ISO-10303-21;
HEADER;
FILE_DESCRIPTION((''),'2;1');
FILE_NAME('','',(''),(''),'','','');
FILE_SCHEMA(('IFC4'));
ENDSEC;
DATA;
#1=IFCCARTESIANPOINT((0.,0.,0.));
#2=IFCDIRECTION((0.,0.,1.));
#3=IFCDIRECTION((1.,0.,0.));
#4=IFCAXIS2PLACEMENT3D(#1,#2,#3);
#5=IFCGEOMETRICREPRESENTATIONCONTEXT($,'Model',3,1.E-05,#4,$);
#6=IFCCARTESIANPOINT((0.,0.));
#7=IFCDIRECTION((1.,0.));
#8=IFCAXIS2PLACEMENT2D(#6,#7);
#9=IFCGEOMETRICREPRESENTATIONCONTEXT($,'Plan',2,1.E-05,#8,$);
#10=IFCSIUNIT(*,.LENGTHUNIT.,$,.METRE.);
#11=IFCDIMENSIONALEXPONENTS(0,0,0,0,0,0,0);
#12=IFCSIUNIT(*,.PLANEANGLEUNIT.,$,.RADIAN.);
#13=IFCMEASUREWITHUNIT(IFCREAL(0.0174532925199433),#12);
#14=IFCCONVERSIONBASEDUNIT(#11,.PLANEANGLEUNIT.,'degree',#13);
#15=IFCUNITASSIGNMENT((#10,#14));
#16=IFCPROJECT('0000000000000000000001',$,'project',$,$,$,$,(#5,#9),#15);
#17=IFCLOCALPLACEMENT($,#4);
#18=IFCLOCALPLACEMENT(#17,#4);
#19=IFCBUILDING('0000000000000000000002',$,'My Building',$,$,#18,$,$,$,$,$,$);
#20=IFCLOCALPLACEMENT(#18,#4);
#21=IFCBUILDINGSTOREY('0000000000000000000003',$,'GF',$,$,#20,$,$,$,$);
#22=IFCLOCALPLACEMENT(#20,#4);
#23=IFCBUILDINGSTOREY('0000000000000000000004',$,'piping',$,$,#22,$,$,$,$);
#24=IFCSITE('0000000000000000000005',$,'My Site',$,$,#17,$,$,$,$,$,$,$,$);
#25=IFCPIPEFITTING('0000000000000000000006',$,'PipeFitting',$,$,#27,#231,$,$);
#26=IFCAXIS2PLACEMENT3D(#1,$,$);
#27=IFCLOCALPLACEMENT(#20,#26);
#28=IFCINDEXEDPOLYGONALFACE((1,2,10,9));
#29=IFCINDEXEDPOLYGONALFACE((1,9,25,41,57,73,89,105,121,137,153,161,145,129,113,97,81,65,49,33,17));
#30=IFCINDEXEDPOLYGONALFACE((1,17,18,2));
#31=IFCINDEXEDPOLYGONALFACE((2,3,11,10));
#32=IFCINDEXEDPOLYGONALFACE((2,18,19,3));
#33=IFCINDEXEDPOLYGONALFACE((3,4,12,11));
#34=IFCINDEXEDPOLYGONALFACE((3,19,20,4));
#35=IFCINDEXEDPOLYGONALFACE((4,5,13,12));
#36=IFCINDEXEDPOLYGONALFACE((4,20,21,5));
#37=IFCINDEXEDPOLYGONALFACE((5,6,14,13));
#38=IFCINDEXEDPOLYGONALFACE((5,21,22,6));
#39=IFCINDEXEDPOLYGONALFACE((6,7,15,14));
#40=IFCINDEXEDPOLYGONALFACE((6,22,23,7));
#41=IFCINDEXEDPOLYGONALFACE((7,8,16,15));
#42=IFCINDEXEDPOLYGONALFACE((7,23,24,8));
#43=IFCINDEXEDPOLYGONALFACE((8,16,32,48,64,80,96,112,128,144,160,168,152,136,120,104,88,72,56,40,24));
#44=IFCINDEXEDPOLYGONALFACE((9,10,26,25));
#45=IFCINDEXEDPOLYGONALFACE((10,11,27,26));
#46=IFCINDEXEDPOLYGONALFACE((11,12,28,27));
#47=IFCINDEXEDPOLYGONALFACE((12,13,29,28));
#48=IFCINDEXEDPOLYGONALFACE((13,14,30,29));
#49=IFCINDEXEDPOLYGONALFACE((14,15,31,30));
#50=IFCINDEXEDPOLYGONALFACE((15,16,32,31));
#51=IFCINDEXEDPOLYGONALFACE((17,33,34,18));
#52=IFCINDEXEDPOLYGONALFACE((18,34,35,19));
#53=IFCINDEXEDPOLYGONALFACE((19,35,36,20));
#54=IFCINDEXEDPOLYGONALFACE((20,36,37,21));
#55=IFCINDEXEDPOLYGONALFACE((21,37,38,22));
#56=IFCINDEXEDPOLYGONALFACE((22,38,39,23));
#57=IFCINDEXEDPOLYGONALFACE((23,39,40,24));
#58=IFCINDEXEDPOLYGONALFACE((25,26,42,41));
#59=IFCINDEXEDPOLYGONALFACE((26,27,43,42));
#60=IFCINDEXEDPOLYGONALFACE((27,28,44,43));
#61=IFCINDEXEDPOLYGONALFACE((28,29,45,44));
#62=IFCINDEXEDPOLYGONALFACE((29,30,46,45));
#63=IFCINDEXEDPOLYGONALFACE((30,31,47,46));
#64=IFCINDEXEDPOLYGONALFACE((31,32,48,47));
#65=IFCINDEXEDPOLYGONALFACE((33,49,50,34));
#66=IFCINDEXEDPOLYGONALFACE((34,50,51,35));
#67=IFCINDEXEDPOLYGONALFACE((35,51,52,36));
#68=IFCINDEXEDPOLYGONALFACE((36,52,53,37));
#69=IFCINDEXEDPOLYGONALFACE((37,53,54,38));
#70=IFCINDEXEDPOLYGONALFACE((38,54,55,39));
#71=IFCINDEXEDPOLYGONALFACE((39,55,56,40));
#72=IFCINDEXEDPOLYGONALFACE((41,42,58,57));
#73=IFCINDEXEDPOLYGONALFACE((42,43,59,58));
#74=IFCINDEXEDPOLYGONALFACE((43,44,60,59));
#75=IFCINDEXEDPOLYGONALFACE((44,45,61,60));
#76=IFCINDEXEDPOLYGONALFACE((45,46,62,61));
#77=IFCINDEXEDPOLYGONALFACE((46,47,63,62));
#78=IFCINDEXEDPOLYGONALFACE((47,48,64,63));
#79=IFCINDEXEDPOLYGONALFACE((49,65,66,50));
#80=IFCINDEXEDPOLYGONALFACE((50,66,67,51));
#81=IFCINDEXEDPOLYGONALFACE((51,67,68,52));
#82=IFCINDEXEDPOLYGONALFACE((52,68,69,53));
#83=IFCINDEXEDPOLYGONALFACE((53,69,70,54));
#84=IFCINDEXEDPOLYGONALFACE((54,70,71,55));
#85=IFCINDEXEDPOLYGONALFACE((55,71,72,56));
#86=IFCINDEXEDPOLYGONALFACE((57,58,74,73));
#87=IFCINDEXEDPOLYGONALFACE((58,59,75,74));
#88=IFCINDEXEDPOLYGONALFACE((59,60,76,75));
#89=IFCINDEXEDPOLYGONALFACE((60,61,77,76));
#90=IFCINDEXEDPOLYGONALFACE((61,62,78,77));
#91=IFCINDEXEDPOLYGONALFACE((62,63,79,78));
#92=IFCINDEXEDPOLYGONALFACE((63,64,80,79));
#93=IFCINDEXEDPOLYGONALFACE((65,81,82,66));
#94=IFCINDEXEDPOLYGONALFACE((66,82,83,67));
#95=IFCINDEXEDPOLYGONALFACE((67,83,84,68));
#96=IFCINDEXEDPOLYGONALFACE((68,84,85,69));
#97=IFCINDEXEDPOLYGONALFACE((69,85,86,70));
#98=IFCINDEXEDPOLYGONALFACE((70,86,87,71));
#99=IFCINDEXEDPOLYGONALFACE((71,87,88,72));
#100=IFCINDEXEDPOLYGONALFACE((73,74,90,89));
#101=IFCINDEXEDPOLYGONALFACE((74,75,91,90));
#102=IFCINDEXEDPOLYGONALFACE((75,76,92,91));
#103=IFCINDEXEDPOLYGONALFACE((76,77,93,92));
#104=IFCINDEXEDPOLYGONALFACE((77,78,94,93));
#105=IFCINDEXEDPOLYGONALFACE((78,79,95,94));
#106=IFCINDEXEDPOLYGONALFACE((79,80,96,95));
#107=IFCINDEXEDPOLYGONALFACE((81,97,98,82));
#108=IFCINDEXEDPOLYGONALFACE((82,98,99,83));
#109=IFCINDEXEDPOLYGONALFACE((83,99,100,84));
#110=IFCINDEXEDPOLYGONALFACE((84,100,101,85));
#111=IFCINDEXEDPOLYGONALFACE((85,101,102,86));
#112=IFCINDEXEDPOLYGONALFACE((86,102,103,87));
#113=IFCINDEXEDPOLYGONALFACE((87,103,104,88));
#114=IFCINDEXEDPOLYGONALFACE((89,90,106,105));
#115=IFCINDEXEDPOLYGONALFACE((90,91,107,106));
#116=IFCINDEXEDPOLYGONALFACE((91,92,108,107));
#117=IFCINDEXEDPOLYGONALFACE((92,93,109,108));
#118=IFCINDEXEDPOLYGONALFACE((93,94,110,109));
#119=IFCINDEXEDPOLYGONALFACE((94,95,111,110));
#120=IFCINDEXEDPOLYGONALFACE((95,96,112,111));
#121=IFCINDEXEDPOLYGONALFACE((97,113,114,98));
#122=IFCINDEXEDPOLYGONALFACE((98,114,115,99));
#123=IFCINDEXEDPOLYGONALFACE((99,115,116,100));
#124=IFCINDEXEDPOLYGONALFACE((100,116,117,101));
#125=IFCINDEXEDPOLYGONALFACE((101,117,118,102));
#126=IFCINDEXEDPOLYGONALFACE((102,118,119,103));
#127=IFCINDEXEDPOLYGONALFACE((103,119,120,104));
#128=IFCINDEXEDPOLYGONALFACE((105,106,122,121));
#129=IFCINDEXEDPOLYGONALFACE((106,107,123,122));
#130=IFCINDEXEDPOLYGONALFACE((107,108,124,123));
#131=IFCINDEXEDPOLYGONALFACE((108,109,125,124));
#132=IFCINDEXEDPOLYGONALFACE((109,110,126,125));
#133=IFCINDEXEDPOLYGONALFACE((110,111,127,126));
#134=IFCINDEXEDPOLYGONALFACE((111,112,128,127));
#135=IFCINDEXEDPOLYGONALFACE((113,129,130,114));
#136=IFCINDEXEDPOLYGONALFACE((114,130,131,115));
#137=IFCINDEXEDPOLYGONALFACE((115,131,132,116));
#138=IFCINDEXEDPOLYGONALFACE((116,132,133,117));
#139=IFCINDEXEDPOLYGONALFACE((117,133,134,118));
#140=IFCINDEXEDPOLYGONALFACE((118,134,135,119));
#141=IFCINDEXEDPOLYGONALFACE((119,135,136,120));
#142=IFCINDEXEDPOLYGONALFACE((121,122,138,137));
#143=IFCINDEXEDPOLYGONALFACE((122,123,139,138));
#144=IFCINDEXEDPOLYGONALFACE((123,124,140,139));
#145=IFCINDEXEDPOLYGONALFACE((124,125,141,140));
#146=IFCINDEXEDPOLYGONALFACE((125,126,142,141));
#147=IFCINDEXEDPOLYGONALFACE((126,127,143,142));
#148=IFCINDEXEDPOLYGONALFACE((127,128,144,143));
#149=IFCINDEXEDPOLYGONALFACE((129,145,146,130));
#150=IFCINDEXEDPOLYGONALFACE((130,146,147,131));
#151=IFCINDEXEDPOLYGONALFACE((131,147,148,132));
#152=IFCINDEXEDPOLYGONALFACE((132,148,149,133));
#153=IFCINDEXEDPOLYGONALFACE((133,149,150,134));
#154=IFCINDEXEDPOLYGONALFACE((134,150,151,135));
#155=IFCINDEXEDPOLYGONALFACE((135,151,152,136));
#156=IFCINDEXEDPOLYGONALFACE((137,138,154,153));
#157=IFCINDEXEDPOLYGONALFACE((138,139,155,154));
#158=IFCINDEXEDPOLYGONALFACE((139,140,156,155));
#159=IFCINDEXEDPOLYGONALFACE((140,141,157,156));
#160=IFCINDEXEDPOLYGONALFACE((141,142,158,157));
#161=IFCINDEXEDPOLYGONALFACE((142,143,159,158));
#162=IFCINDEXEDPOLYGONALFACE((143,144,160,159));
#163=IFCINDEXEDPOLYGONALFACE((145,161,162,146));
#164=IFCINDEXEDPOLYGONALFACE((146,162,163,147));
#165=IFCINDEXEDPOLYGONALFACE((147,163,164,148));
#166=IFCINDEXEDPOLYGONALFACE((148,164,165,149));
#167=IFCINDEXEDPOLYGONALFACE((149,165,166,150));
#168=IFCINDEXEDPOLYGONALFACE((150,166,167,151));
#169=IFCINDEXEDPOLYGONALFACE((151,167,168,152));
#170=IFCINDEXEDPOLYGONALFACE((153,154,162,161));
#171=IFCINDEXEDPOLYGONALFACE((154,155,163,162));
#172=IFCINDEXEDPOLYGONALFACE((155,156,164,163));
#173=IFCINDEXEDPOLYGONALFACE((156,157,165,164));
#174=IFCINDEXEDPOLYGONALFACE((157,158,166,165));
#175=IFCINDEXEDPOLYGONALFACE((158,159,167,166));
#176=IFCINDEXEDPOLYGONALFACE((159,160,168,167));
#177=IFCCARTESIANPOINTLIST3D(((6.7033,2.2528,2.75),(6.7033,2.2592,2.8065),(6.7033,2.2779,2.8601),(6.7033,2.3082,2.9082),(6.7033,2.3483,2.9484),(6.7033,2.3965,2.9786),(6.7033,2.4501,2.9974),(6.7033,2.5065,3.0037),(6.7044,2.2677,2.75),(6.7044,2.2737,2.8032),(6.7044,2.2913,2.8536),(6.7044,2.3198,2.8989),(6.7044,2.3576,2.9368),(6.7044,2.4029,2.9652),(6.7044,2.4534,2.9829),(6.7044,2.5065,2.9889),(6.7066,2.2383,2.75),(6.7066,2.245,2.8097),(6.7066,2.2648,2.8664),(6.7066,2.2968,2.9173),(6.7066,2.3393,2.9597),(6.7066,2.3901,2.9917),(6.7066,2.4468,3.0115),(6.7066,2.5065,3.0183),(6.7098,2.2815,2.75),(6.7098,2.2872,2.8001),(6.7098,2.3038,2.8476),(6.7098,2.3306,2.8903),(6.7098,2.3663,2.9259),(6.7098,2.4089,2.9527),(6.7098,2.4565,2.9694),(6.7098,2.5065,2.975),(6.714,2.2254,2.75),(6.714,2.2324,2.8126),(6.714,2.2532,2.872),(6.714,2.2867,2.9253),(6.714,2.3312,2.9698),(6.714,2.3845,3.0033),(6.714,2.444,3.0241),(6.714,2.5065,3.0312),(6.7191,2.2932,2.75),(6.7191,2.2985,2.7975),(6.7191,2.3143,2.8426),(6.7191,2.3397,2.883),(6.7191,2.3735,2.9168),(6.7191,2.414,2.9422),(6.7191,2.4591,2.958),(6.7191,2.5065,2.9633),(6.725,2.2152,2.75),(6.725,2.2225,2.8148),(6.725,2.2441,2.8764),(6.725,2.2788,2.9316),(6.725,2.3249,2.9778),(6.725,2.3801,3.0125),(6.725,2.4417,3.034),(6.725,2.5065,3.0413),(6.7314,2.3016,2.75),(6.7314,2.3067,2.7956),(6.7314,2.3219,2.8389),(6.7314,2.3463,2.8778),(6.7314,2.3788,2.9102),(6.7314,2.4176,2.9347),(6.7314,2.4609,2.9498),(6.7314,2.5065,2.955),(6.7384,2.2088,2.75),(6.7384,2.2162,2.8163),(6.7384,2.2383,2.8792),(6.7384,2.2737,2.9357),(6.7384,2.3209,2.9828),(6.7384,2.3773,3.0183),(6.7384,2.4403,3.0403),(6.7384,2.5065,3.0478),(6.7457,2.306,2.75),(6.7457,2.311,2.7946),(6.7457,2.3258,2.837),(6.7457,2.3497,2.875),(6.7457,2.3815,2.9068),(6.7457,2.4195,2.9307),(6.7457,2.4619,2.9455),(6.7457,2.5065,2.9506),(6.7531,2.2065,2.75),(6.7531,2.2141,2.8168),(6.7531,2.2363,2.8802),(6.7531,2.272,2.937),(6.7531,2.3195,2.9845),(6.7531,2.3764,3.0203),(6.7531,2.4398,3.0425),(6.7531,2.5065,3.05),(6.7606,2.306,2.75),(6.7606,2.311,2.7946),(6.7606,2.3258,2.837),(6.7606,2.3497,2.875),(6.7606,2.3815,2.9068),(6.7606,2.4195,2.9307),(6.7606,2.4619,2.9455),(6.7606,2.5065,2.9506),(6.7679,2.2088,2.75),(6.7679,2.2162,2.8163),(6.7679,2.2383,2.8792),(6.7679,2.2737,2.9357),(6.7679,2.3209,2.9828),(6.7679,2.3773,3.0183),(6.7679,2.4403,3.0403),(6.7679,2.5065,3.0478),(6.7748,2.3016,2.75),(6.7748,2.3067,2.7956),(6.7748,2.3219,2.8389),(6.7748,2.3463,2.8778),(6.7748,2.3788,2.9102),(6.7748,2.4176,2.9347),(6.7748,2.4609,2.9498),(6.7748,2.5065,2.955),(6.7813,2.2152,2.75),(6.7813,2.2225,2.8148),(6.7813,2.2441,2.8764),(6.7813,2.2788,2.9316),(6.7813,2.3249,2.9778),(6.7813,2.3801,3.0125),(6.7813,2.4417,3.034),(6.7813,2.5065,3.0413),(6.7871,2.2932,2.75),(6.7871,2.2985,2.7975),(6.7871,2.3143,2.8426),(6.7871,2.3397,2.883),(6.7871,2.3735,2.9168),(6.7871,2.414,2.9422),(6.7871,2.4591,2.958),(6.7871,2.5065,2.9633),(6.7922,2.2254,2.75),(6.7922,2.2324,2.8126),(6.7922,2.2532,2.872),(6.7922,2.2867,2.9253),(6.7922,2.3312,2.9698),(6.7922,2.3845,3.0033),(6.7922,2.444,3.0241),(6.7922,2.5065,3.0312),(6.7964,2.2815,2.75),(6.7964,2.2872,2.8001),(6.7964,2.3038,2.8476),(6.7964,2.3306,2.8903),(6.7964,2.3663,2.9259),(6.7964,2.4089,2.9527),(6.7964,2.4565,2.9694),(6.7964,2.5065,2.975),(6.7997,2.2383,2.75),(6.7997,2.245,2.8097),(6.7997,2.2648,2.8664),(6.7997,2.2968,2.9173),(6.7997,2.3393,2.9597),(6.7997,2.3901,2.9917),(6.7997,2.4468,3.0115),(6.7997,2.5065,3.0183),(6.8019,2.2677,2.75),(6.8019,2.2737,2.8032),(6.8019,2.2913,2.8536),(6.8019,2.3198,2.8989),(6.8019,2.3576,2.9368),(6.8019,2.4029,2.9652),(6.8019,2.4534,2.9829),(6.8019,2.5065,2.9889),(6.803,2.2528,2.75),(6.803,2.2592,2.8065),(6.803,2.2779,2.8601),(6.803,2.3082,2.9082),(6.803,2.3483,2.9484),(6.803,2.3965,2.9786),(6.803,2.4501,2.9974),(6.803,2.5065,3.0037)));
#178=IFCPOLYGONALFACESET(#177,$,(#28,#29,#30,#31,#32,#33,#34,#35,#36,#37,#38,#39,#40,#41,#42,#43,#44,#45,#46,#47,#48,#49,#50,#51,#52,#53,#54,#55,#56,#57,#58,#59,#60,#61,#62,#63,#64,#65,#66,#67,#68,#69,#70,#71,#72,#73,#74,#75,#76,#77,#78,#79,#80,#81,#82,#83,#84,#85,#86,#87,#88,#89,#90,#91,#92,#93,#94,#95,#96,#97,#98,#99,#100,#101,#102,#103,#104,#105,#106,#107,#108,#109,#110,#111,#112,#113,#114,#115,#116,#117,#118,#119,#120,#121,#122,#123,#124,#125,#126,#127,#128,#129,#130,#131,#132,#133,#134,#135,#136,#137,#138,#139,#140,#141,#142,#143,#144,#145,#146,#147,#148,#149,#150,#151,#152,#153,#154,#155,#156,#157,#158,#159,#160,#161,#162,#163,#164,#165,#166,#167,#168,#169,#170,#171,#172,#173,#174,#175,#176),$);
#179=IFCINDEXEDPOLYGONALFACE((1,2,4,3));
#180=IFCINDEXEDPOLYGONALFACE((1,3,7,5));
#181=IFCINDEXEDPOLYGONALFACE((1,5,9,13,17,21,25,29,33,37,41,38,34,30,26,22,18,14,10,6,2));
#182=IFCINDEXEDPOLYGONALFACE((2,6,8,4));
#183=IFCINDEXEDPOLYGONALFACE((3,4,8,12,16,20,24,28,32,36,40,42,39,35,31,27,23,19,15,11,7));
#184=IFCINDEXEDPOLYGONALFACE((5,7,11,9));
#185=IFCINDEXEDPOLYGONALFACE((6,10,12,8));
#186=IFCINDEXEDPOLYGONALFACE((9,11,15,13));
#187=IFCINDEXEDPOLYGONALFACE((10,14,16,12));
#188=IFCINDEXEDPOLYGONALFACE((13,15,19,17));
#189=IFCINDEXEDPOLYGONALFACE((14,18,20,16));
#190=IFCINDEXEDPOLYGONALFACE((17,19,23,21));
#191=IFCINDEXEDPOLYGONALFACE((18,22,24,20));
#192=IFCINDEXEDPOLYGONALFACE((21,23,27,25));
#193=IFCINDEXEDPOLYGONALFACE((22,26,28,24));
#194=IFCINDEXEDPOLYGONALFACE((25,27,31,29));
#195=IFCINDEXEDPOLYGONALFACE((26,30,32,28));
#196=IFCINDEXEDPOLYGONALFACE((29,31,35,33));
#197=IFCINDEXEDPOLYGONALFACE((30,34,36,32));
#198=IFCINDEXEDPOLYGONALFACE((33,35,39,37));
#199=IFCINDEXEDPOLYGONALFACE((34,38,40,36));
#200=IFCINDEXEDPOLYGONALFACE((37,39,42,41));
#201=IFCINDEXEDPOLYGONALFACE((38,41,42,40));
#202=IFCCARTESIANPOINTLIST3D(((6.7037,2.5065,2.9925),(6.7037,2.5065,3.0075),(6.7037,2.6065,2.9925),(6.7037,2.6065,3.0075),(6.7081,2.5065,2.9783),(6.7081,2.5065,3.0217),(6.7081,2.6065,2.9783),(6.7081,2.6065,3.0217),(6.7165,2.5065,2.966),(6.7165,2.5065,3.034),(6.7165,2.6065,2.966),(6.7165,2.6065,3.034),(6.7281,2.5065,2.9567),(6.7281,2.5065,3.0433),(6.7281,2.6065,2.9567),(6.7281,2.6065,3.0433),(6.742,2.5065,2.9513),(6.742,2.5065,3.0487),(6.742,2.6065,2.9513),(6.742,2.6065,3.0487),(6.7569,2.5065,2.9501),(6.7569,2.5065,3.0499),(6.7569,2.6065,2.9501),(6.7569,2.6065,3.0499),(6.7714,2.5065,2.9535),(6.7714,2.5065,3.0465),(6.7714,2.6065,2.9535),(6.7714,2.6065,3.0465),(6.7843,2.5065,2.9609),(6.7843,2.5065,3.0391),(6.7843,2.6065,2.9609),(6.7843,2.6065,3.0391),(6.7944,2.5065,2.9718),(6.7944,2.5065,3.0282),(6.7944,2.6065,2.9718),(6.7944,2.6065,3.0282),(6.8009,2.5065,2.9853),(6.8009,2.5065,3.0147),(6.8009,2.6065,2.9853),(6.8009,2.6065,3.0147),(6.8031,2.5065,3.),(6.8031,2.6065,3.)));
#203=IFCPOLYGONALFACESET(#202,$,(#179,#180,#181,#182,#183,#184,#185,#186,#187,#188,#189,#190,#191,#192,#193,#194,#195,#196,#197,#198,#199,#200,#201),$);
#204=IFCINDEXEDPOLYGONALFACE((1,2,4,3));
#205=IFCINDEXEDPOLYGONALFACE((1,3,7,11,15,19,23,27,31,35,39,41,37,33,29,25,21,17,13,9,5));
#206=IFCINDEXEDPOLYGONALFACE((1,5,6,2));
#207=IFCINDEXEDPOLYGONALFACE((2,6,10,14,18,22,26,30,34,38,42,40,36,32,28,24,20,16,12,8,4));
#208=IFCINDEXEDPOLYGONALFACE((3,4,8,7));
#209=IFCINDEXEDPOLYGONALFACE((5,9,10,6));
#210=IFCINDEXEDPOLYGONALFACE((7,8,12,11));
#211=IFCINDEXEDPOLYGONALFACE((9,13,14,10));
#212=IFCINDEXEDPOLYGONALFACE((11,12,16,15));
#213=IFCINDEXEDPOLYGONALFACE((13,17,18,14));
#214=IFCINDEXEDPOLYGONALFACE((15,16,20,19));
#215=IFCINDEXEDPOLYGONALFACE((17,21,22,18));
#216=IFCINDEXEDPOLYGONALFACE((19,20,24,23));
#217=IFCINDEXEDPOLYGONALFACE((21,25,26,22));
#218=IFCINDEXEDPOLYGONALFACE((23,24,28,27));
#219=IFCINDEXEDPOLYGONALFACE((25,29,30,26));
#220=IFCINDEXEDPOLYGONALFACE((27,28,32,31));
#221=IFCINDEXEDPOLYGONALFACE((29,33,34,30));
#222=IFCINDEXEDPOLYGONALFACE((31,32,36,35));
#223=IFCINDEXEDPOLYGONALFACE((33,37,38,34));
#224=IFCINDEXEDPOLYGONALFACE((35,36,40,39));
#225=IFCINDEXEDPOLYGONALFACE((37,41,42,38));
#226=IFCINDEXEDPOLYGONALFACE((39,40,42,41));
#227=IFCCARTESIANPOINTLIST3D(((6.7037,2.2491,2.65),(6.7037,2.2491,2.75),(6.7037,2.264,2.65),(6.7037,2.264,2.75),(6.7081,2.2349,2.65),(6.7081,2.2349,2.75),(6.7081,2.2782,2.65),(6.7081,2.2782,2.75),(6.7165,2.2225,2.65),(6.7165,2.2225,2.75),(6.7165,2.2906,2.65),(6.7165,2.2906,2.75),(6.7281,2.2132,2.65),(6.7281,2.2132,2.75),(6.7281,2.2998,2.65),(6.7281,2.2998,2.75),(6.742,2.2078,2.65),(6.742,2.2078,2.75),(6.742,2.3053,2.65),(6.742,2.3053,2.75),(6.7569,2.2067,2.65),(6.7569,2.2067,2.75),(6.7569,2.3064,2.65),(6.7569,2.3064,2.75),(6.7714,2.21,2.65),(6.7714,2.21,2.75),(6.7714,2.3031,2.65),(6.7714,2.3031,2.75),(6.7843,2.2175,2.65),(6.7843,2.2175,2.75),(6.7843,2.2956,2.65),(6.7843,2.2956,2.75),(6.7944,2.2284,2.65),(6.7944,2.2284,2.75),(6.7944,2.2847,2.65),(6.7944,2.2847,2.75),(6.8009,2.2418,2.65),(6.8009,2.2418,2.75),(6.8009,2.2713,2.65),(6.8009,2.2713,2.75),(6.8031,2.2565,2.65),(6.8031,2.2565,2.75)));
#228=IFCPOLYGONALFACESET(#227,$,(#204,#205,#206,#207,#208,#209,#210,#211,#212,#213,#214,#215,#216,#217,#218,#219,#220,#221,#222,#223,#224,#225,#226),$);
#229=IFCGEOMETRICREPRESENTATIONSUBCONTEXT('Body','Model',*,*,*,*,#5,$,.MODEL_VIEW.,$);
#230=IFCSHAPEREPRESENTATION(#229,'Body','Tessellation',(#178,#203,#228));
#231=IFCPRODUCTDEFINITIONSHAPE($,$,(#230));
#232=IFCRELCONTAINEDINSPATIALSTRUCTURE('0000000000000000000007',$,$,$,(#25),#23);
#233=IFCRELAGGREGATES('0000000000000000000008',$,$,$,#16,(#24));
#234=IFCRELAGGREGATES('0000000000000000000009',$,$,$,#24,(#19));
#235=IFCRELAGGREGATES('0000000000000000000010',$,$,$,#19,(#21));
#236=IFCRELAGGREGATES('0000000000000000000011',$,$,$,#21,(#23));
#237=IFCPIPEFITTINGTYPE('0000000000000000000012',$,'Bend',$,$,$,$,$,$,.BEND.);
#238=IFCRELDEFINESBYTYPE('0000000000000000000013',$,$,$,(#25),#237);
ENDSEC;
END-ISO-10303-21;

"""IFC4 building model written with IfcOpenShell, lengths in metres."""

from ifc_helpers import new_model, entity, si_unit, converted_unit, frame, origin_with_axes, origin_2d_with_axis, place, context, subcontext, project, spatial, circle, extrude, source, transform, mapped, type_object, type_shapes, element, save


model = new_model("IFC4")

# Units and contexts
model_context = context("Model", 3, precision=1e-05, world=origin_with_axes())
plan_context = context("Plan", 2, precision=1e-05, world=origin_2d_with_axis())
body_context = subcontext(model_context, "Body", "Model", "MODEL_VIEW")
ifc_project = project(units=[si_unit("LENGTHUNIT", "METRE"), converted_unit("PLANEANGLEUNIT", "degree", entity("IfcReal", 0.0174532925199433), si_unit("PLANEANGLEUNIT", "RADIAN"), dimensions=[0, 0, 0, 0, 0, 0, 0])], contexts=[model_context, plan_context])

# Site, building, storeys
site_placement = place(None, origin_with_axes())
site = spatial("IfcSite", under=ifc_project, at=site_placement, Name="My Site")
building_placement = place(site_placement, origin_with_axes())
building = spatial("IfcBuilding", under=site, at=building_placement, Name="My Building")
storey_1_placement = place(building_placement, origin_with_axes())
storey_1 = spatial("IfcBuildingStorey", under=building, at=storey_1_placement, Name="GF")
storey_2_placement = place(storey_1_placement, origin_with_axes())
storey_2 = spatial("IfcBuildingStorey", under=storey_1, at=storey_2_placement, Name="piping")

# Pipe fitting
pipe_fitting_type = type_object("IfcPipeFittingType", Name="Bend", PredefinedType="BEND")
shared_shape = source(origin_with_axes(), body_context, "Body", "SolidModel", [
    entity("IfcSweptDiskSolid", entity("IfcIndexedPolyCurve", entity("IfcCartesianPointList3D", [[0.0, 0.0, 0.1], [0.0, -0.0732, 0.2768], [0.0, -0.25, 0.35]]), [entity("IfcArcIndex", [1, 2, 3])]), 0.05),
    extrude(circle(Radius=0.05), origin_with_axes(), (0.0, 0.0, 1.0), 0.1),
    extrude(circle(Radius=0.05), frame((0.0, -0.25, 0.35), z_axis=(0.0, -1.0, 0.0), x_axis=(1.0, 0.0, 0.0)), (0.0, 0.0, 1.0), 0.1),
])
type_shapes(pipe_fitting_type, [shared_shape])
for number, where, z_axis, x_axis, name in (
    (1, (6.7531, 2.6065, 3.0), (0.0, -1.0, 0.0), (1.0, 0.0, 0.0), "PipeFitting"),
):
    element("IfcPipeFitting", number, at=place(storey_2_placement, frame(where, z_axis=z_axis, x_axis=x_axis)), inside=storey_2, type_object=pipe_fitting_type, Name=name, context=body_context, shape_type="MappedRepresentation", body=[
        mapped(shared_shape, transform((0.0, 0.0, 0.0), x_axis=(1.0, 0.0, 0.0), y_axis=(0.0, 1.0, 0.0), z_axis=(0.0, 0.0, 1.0), scale=1.0)),
    ])

save(model, "model.ifc")
